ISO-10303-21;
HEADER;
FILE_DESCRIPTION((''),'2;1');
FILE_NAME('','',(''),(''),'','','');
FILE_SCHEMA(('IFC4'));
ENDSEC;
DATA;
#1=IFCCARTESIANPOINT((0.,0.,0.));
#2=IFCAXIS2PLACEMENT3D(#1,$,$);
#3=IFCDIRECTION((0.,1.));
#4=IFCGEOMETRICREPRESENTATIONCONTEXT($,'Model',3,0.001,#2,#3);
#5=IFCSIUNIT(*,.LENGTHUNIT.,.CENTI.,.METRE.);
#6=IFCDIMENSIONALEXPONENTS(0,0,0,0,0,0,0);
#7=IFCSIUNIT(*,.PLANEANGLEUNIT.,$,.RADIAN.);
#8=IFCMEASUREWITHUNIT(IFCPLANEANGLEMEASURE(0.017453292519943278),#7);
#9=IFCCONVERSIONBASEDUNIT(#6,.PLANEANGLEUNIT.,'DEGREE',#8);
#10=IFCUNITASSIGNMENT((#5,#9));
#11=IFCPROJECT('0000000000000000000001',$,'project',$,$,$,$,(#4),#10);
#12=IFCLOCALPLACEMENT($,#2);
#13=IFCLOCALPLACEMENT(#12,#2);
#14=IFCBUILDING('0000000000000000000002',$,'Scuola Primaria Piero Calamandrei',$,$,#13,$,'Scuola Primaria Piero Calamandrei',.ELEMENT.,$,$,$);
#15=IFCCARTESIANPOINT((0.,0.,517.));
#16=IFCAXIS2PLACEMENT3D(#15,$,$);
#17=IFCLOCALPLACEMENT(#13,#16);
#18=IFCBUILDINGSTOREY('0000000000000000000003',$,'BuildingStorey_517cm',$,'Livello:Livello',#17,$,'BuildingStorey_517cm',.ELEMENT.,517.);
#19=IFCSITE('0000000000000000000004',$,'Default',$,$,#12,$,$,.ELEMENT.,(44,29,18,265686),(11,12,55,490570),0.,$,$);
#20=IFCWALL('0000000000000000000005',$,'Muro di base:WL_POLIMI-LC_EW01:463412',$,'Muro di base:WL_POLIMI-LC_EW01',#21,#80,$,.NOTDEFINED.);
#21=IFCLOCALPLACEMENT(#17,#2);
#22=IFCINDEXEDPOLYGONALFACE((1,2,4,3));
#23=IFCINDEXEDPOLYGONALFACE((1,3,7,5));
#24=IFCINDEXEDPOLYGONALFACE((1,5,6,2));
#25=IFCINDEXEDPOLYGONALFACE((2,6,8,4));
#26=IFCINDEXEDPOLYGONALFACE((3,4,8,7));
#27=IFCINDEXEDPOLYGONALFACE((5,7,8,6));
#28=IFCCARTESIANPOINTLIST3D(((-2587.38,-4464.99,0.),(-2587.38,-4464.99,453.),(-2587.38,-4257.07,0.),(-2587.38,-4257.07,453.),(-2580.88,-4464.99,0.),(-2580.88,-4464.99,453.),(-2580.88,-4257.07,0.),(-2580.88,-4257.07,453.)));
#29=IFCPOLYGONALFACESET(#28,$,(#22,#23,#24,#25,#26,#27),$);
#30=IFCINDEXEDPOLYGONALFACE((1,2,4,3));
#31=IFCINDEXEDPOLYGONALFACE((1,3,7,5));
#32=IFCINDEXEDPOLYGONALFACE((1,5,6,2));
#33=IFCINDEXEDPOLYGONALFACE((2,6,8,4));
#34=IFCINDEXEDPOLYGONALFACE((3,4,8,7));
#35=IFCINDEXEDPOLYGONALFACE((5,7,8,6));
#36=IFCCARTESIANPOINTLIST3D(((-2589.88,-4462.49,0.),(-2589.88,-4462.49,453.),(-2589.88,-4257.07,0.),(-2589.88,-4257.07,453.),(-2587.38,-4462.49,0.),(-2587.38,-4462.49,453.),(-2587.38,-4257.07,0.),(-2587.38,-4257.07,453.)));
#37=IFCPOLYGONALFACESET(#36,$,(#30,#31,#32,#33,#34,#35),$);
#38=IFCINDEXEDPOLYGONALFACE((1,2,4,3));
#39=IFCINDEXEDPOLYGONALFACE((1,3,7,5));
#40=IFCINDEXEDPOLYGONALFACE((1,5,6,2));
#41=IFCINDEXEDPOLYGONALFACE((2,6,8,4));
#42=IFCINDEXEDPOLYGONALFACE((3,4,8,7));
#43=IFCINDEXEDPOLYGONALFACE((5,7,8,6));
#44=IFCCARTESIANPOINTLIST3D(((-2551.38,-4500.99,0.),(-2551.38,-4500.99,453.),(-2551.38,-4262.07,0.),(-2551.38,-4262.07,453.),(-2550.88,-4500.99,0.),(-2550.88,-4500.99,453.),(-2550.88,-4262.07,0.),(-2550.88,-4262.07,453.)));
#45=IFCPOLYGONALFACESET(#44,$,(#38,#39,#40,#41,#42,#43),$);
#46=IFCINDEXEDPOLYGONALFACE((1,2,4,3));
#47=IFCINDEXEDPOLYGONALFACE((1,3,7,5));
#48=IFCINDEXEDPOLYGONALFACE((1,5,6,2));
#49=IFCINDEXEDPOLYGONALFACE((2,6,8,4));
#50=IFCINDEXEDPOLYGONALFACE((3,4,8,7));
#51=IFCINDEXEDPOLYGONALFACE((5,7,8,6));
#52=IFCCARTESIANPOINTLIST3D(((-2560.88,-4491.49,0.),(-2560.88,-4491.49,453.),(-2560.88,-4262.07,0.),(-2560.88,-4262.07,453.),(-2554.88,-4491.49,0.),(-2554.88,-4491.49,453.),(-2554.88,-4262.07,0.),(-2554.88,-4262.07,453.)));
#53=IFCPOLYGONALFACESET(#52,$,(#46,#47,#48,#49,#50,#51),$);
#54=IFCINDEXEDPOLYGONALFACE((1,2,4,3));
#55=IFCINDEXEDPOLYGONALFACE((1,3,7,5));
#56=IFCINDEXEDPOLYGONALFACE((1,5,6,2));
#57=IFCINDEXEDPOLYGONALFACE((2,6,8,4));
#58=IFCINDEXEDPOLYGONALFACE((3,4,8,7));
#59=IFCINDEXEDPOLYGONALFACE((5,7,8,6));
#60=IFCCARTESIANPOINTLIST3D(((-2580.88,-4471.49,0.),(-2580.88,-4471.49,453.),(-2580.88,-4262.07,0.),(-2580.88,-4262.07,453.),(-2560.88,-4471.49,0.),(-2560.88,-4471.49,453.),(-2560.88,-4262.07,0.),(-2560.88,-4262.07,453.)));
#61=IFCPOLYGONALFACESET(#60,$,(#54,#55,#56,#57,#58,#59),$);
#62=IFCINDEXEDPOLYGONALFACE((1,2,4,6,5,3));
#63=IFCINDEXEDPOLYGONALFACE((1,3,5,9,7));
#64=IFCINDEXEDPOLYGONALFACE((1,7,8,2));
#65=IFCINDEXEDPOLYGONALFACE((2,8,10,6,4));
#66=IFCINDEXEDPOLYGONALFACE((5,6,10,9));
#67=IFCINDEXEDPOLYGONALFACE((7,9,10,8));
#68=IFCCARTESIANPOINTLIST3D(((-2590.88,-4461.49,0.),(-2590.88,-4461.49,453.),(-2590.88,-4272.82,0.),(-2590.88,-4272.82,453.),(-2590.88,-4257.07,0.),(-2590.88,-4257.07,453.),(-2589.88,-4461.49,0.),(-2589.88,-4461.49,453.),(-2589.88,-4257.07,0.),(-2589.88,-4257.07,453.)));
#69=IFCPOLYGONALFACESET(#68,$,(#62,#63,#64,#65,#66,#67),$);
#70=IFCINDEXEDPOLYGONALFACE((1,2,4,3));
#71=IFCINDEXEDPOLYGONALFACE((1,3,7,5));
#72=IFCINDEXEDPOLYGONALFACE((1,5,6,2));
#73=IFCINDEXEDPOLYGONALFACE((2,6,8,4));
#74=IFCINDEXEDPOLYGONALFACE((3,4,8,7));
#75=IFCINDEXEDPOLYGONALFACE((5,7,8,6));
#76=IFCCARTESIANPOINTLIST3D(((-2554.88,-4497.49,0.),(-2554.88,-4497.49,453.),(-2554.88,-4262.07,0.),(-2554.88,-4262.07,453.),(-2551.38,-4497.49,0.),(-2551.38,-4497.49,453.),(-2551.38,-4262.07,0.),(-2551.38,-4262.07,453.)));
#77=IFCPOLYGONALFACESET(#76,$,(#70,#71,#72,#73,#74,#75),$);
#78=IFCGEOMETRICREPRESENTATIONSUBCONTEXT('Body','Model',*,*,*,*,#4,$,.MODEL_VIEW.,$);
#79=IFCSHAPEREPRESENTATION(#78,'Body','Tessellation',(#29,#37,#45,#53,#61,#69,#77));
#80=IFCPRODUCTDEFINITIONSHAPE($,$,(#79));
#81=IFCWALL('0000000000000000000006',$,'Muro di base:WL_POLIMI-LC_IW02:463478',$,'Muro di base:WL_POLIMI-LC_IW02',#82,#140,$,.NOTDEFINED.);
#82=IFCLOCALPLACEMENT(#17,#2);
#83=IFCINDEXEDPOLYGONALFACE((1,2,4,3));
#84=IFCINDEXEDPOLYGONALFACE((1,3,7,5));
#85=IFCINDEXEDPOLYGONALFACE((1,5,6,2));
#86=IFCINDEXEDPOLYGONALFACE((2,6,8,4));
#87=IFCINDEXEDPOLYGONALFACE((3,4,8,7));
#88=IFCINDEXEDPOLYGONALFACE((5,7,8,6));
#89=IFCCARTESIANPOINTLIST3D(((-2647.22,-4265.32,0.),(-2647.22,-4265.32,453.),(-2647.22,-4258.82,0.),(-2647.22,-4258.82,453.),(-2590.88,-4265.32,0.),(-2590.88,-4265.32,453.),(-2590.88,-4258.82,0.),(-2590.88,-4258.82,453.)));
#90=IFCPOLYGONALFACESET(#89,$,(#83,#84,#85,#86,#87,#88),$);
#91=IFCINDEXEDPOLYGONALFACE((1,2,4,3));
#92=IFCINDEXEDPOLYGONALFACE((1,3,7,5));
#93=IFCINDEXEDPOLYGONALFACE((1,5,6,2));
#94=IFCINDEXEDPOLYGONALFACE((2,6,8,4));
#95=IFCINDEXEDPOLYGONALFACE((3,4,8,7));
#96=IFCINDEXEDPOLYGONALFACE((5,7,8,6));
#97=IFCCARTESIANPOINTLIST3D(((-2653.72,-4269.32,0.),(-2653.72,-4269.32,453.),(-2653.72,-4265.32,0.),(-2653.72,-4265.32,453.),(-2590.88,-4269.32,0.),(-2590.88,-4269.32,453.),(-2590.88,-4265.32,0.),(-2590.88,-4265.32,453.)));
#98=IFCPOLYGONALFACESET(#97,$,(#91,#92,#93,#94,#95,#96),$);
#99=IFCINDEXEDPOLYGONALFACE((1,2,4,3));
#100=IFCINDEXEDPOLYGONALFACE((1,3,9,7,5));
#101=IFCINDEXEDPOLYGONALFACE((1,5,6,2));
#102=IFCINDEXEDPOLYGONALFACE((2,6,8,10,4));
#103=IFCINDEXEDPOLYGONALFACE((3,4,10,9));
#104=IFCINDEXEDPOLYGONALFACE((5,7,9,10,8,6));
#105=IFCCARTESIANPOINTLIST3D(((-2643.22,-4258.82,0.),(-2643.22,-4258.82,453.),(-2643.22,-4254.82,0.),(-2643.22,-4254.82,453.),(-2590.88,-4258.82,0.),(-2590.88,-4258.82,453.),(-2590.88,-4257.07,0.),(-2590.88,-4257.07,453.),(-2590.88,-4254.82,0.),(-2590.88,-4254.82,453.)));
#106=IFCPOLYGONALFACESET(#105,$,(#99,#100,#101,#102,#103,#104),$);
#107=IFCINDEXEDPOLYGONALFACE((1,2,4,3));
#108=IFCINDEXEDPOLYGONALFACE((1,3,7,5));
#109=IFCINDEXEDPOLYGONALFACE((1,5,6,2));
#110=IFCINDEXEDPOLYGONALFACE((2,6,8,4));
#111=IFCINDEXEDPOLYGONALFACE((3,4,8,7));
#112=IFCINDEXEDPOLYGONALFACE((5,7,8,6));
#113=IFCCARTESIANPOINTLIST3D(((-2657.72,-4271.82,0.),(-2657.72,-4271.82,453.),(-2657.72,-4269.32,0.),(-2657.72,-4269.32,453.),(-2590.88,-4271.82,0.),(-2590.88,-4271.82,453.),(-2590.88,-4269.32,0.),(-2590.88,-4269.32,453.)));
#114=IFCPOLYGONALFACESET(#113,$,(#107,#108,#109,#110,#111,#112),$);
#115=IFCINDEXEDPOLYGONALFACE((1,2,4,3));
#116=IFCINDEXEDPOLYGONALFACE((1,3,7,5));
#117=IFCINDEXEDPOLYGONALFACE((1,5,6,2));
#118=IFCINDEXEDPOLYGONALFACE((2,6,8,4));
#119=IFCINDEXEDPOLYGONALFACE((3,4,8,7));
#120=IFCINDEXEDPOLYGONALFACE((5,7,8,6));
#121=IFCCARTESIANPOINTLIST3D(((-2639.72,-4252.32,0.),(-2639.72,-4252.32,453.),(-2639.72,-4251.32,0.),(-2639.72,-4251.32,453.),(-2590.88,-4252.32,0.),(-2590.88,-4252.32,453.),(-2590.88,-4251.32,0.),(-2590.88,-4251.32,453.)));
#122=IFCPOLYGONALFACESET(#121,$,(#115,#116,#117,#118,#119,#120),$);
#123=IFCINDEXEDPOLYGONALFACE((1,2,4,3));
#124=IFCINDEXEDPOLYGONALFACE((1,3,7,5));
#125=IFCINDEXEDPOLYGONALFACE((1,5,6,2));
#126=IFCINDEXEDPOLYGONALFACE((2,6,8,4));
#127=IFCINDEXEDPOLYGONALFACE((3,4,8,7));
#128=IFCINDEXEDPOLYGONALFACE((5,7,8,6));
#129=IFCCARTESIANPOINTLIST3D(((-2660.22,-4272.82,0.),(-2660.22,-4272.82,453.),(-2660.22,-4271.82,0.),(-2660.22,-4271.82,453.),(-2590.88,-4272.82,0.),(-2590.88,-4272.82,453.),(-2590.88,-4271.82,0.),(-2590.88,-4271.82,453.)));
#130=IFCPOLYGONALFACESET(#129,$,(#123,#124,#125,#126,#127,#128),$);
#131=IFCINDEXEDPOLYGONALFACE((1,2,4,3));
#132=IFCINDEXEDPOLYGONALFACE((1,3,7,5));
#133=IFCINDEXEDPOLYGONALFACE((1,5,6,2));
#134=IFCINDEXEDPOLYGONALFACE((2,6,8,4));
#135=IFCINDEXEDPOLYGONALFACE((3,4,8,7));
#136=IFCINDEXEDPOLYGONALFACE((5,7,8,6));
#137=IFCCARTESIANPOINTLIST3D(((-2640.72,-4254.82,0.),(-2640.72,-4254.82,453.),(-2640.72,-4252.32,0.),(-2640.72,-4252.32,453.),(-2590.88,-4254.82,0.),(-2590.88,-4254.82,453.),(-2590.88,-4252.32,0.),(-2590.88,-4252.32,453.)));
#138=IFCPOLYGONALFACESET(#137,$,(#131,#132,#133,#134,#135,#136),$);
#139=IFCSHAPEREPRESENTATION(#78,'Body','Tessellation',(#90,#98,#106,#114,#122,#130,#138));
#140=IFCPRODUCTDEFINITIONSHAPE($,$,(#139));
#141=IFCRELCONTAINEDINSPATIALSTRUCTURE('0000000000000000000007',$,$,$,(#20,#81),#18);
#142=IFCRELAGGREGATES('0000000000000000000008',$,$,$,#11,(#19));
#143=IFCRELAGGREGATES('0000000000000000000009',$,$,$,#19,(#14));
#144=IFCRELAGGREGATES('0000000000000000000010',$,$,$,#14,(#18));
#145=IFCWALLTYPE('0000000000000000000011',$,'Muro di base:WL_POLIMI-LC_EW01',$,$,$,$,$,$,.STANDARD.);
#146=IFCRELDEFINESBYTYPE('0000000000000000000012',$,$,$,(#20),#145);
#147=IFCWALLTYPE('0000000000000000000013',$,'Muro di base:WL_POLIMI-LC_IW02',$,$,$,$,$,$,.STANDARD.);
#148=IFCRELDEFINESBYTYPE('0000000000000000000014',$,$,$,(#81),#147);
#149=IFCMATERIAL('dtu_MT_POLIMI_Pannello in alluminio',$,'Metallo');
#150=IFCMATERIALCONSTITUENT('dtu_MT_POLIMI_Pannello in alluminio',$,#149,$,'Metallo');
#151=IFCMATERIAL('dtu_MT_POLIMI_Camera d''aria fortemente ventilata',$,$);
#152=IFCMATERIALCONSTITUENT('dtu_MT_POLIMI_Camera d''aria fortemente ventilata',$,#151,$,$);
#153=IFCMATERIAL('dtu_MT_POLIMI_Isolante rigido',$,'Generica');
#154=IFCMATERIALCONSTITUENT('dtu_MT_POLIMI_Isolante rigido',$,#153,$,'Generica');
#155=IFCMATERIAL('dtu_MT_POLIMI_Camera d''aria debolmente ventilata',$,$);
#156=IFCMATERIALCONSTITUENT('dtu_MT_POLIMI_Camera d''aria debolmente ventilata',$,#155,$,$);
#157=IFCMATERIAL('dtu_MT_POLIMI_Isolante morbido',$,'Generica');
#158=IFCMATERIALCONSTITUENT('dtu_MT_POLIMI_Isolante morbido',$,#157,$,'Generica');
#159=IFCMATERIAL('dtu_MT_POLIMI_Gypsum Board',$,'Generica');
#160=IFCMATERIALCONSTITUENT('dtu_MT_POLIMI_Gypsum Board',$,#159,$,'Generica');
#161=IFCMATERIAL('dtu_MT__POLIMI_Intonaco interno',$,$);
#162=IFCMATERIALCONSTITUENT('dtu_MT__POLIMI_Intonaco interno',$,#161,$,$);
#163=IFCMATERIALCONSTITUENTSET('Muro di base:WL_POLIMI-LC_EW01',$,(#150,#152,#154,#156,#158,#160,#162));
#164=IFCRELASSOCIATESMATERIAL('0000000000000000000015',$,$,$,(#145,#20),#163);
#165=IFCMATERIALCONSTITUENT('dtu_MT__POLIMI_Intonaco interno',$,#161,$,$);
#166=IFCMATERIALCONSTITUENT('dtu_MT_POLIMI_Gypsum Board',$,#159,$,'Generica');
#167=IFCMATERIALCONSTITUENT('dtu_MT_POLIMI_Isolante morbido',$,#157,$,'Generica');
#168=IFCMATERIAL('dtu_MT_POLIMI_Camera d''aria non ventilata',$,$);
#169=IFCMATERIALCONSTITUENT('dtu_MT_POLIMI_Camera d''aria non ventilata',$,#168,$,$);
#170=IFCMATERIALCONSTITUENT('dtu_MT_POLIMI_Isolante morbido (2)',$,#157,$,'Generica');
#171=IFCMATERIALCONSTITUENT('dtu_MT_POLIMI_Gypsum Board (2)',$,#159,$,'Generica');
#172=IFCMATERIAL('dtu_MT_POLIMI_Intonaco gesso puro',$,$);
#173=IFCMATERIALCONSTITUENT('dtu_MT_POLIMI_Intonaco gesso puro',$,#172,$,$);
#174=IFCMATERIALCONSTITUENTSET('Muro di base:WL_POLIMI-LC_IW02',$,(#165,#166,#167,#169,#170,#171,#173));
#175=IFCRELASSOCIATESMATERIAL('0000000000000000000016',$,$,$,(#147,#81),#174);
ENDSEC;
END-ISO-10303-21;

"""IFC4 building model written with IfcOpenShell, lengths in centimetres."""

from ifc_helpers import new_model, entity, si_unit, converted_unit, direction, frame, origin, place, context, subcontext, project, spatial, indexed_curve, outline, extrude, material, constituent, constituent_set, type_object, element, save


model = new_model("IFC4")

# Units and contexts
model_context = context("Model", 3, precision=0.001, world=origin(), true_north=direction((0.0, 1.0)))
body_context = subcontext(model_context, "Body", "Model", "MODEL_VIEW")
ifc_project = project(units=[si_unit("LENGTHUNIT", "METRE", prefix="CENTI"), converted_unit("PLANEANGLEUNIT", "DEGREE", entity("IfcPlaneAngleMeasure", 0.017453292519943278), si_unit("PLANEANGLEUNIT", "RADIAN"), dimensions=[0, 0, 0, 0, 0, 0, 0])], contexts=[model_context])

# Site, building, storey
site_placement = place(None, origin())
site = spatial("IfcSite", under=ifc_project, at=site_placement, Name="Default", CompositionType="ELEMENT", RefLatitude=(44, 29, 18, 265686), RefLongitude=(11, 12, 55, 490570), RefElevation=0.0)
building_placement = place(site_placement, origin())
building = spatial("IfcBuilding", under=site, at=building_placement, Name="Scuola Primaria Piero Calamandrei", LongName="Scuola Primaria Piero Calamandrei", CompositionType="ELEMENT")
storey_placement = place(building_placement, frame((0.0, 0.0, 517.0)))
storey = spatial("IfcBuildingStorey", under=building, at=storey_placement, Name="BuildingStorey_517cm", ObjectType="Livello:Livello", LongName="BuildingStorey_517cm", CompositionType="ELEMENT", Elevation=517.0)

# Shared definitions
ifc_material_1 = material(Name="dtu_MT_POLIMI_Pannello in alluminio", Category="Metallo")
ifc_constituent_1 = constituent(ifc_material_1, Name="dtu_MT_POLIMI_Pannello in alluminio", Category="Metallo")
ifc_material_2 = material(Name="dtu_MT_POLIMI_Camera d'aria fortemente ventilata")
ifc_constituent_2 = constituent(ifc_material_2, Name="dtu_MT_POLIMI_Camera d'aria fortemente ventilata")
ifc_material_3 = material(Name="dtu_MT_POLIMI_Isolante rigido", Category="Generica")
ifc_constituent_3 = constituent(ifc_material_3, Name="dtu_MT_POLIMI_Isolante rigido", Category="Generica")
ifc_material_4 = material(Name="dtu_MT_POLIMI_Camera d'aria debolmente ventilata")
ifc_constituent_4 = constituent(ifc_material_4, Name="dtu_MT_POLIMI_Camera d'aria debolmente ventilata")
ifc_material_5 = material(Name="dtu_MT_POLIMI_Isolante morbido", Category="Generica")
ifc_constituent_5 = constituent(ifc_material_5, Name="dtu_MT_POLIMI_Isolante morbido", Category="Generica")
ifc_material_6 = material(Name="dtu_MT_POLIMI_Gypsum Board", Category="Generica")
ifc_constituent_6 = constituent(ifc_material_6, Name="dtu_MT_POLIMI_Gypsum Board", Category="Generica")
ifc_material_7 = material(Name="dtu_MT__POLIMI_Intonaco interno")
ifc_constituent_7 = constituent(ifc_material_7, Name="dtu_MT__POLIMI_Intonaco interno")
ifc_constituent_set_1 = constituent_set(constituents=[ifc_constituent_1, ifc_constituent_2, ifc_constituent_3, ifc_constituent_4, ifc_constituent_5, ifc_constituent_6, ifc_constituent_7], Name="Muro di base:WL_POLIMI-LC_EW01")
wall_type_1 = type_object("IfcWallType", Name="Muro di base:WL_POLIMI-LC_EW01", PredefinedType="STANDARD", material=ifc_constituent_set_1)

# Wall
wall_1_placement = place(storey_placement, frame((-2570.88, -4257.07, 0.0), z_axis=(0.0, 0.0, 1.0), x_axis=(0.0, -1.0, 0.0)))
element("IfcWall", 1, at=wall_1_placement, inside=storey, type_object=wall_type_1, material=ifc_constituent_set_1, Name="Muro di base:WL_POLIMI-LC_EW01:463412", ObjectType="Muro di base:WL_POLIMI-LC_EW01", PredefinedType="NOTDEFINED", context=body_context, shape_type="SweptSolid", body=[
    extrude(outline(indexed_curve([(-103.96, -3.25), (103.96, -3.25), (103.96, 3.25), (-103.96, 3.25), (-103.96, -3.25)], self_intersect=False)), frame((103.96, -13.25, 0.0)), (0.0, 0.0, 1.0), 453.0),
    extrude(outline(indexed_curve([(-102.71, -1.25), (102.71, -1.25), (102.71, 1.25), (-102.71, 1.25), (-102.71, -1.25)], self_intersect=False)), frame((102.71, -17.75, 0.0)), (0.0, 0.0, 1.0), 453.0),
    extrude(outline(indexed_curve([(-0.25, -119.46), (0.25, -119.46), (0.25, 119.46), (-0.25, 119.46), (-0.25, -119.46)], self_intersect=False)), frame((124.46, 19.75, 0.0), z_axis=(0.0, 0.0, 1.0), x_axis=(0.0, -1.0, 0.0)), (0.0, 0.0, 1.0), 453.0),
    extrude(outline(indexed_curve([(-114.71, -3.0), (114.71, -3.0), (114.71, 3.0), (-114.71, 3.0), (-114.71, -3.0)], self_intersect=False)), frame((119.71, 13.0, 0.0)), (0.0, 0.0, 1.0), 453.0),
    extrude(outline(indexed_curve([(-104.71, -10.0), (104.71, -10.0), (104.71, 10.0), (-104.71, 10.0), (-104.71, -10.0)], self_intersect=False)), frame((109.71, 0.0, 0.0)), (0.0, 0.0, 1.0), 453.0),
    extrude(outline(indexed_curve([(-69.17, -0.4), (119.5, -0.4), (119.5, 0.6), (-84.92, 0.6), (-84.92, -0.4), (-69.17, -0.4)], self_intersect=False)), frame((84.92, -19.6, 0.0)), (0.0, 0.0, 1.0), 453.0),
    extrude(outline(indexed_curve([(-117.71, -1.75), (117.71, -1.75), (117.71, 1.75), (-117.71, 1.75), (-117.71, -1.75)], self_intersect=False)), frame((122.71, 17.75, 0.0)), (0.0, 0.0, 1.0), 453.0),
])

# Shared definitions
ifc_constituent_8 = constituent(ifc_material_7, Name="dtu_MT__POLIMI_Intonaco interno")
ifc_constituent_9 = constituent(ifc_material_6, Name="dtu_MT_POLIMI_Gypsum Board", Category="Generica")
ifc_constituent_10 = constituent(ifc_material_5, Name="dtu_MT_POLIMI_Isolante morbido", Category="Generica")
ifc_material_8 = material(Name="dtu_MT_POLIMI_Camera d'aria non ventilata")
ifc_constituent_11 = constituent(ifc_material_8, Name="dtu_MT_POLIMI_Camera d'aria non ventilata")
ifc_constituent_12 = constituent(ifc_material_5, Name="dtu_MT_POLIMI_Isolante morbido (2)", Category="Generica")
ifc_constituent_13 = constituent(ifc_material_6, Name="dtu_MT_POLIMI_Gypsum Board (2)", Category="Generica")
ifc_material_9 = material(Name="dtu_MT_POLIMI_Intonaco gesso puro")
ifc_constituent_14 = constituent(ifc_material_9, Name="dtu_MT_POLIMI_Intonaco gesso puro")
ifc_constituent_set_2 = constituent_set(constituents=[ifc_constituent_8, ifc_constituent_9, ifc_constituent_10, ifc_constituent_11, ifc_constituent_12, ifc_constituent_13, ifc_constituent_14], Name="Muro di base:WL_POLIMI-LC_IW02")
wall_type_2 = type_object("IfcWallType", Name="Muro di base:WL_POLIMI-LC_IW02", PredefinedType="STANDARD", material=ifc_constituent_set_2)

# Wall
wall_2_placement = place(storey_placement, frame((-2590.88, -4262.07, 0.0), z_axis=(0.0, 0.0, 1.0), x_axis=(-1.0, 0.0, 0.0)))
element("IfcWall", 2, at=wall_2_placement, inside=storey, type_object=wall_type_2, material=ifc_constituent_set_2, Name="Muro di base:WL_POLIMI-LC_IW02:463478", ObjectType="Muro di base:WL_POLIMI-LC_IW02", PredefinedType="NOTDEFINED", context=body_context, shape_type="SweptSolid", body=[
    extrude(outline(indexed_curve([(-28.17, -3.25), (28.17, -3.25), (28.17, 3.25), (-28.17, 3.25), (-28.17, -3.25)], self_intersect=False)), frame((28.17, 0.0, 0.0)), (0.0, 0.0, 1.0), 453.0),
    extrude(outline(indexed_curve([(-31.42, -2.0), (31.42, -2.0), (31.42, 2.0), (-31.42, 2.0), (-31.42, -2.0)], self_intersect=False)), frame((31.42, 5.25, 0.0)), (0.0, 0.0, 1.0), 453.0),
    extrude(outline(indexed_curve([(-20.94, -2.05), (31.41, -2.05), (31.41, 1.95), (-20.94, 1.95), (-20.94, 0.2), (-20.94, -2.05)], self_intersect=False)), frame((20.94, -5.2, 0.0)), (0.0, 0.0, 1.0), 453.0),
    extrude(outline(indexed_curve([(-33.42, -1.25), (33.42, -1.25), (33.42, 1.25), (-33.42, 1.25), (-33.42, -1.25)], self_intersect=False)), frame((33.42, 8.5, 0.0)), (0.0, 0.0, 1.0), 453.0),
    extrude(outline(indexed_curve([(-0.5, -24.42), (0.5, -24.42), (0.5, 24.42), (-0.5, 24.42), (-0.5, -24.42)], self_intersect=False)), frame((24.42, -10.25, 0.0), z_axis=(0.0, 0.0, 1.0), x_axis=(0.0, 1.0, 0.0)), (0.0, 0.0, 1.0), 453.0),
    extrude(outline(indexed_curve([(-0.5, -34.67), (0.5, -34.67), (0.5, 34.67), (-0.5, 34.67), (-0.5, -34.67)], self_intersect=False)), frame((34.67, 10.25, 0.0), z_axis=(0.0, 0.0, 1.0), x_axis=(0.0, -1.0, 0.0)), (0.0, 0.0, 1.0), 453.0),
    extrude(outline(indexed_curve([(-24.92, -1.25), (24.92, -1.25), (24.92, 1.25), (-24.92, 1.25), (-24.92, -1.25)], self_intersect=False)), frame((24.92, -8.5, 0.0)), (0.0, 0.0, 1.0), 453.0),
])

save(model, "model.ifc")
